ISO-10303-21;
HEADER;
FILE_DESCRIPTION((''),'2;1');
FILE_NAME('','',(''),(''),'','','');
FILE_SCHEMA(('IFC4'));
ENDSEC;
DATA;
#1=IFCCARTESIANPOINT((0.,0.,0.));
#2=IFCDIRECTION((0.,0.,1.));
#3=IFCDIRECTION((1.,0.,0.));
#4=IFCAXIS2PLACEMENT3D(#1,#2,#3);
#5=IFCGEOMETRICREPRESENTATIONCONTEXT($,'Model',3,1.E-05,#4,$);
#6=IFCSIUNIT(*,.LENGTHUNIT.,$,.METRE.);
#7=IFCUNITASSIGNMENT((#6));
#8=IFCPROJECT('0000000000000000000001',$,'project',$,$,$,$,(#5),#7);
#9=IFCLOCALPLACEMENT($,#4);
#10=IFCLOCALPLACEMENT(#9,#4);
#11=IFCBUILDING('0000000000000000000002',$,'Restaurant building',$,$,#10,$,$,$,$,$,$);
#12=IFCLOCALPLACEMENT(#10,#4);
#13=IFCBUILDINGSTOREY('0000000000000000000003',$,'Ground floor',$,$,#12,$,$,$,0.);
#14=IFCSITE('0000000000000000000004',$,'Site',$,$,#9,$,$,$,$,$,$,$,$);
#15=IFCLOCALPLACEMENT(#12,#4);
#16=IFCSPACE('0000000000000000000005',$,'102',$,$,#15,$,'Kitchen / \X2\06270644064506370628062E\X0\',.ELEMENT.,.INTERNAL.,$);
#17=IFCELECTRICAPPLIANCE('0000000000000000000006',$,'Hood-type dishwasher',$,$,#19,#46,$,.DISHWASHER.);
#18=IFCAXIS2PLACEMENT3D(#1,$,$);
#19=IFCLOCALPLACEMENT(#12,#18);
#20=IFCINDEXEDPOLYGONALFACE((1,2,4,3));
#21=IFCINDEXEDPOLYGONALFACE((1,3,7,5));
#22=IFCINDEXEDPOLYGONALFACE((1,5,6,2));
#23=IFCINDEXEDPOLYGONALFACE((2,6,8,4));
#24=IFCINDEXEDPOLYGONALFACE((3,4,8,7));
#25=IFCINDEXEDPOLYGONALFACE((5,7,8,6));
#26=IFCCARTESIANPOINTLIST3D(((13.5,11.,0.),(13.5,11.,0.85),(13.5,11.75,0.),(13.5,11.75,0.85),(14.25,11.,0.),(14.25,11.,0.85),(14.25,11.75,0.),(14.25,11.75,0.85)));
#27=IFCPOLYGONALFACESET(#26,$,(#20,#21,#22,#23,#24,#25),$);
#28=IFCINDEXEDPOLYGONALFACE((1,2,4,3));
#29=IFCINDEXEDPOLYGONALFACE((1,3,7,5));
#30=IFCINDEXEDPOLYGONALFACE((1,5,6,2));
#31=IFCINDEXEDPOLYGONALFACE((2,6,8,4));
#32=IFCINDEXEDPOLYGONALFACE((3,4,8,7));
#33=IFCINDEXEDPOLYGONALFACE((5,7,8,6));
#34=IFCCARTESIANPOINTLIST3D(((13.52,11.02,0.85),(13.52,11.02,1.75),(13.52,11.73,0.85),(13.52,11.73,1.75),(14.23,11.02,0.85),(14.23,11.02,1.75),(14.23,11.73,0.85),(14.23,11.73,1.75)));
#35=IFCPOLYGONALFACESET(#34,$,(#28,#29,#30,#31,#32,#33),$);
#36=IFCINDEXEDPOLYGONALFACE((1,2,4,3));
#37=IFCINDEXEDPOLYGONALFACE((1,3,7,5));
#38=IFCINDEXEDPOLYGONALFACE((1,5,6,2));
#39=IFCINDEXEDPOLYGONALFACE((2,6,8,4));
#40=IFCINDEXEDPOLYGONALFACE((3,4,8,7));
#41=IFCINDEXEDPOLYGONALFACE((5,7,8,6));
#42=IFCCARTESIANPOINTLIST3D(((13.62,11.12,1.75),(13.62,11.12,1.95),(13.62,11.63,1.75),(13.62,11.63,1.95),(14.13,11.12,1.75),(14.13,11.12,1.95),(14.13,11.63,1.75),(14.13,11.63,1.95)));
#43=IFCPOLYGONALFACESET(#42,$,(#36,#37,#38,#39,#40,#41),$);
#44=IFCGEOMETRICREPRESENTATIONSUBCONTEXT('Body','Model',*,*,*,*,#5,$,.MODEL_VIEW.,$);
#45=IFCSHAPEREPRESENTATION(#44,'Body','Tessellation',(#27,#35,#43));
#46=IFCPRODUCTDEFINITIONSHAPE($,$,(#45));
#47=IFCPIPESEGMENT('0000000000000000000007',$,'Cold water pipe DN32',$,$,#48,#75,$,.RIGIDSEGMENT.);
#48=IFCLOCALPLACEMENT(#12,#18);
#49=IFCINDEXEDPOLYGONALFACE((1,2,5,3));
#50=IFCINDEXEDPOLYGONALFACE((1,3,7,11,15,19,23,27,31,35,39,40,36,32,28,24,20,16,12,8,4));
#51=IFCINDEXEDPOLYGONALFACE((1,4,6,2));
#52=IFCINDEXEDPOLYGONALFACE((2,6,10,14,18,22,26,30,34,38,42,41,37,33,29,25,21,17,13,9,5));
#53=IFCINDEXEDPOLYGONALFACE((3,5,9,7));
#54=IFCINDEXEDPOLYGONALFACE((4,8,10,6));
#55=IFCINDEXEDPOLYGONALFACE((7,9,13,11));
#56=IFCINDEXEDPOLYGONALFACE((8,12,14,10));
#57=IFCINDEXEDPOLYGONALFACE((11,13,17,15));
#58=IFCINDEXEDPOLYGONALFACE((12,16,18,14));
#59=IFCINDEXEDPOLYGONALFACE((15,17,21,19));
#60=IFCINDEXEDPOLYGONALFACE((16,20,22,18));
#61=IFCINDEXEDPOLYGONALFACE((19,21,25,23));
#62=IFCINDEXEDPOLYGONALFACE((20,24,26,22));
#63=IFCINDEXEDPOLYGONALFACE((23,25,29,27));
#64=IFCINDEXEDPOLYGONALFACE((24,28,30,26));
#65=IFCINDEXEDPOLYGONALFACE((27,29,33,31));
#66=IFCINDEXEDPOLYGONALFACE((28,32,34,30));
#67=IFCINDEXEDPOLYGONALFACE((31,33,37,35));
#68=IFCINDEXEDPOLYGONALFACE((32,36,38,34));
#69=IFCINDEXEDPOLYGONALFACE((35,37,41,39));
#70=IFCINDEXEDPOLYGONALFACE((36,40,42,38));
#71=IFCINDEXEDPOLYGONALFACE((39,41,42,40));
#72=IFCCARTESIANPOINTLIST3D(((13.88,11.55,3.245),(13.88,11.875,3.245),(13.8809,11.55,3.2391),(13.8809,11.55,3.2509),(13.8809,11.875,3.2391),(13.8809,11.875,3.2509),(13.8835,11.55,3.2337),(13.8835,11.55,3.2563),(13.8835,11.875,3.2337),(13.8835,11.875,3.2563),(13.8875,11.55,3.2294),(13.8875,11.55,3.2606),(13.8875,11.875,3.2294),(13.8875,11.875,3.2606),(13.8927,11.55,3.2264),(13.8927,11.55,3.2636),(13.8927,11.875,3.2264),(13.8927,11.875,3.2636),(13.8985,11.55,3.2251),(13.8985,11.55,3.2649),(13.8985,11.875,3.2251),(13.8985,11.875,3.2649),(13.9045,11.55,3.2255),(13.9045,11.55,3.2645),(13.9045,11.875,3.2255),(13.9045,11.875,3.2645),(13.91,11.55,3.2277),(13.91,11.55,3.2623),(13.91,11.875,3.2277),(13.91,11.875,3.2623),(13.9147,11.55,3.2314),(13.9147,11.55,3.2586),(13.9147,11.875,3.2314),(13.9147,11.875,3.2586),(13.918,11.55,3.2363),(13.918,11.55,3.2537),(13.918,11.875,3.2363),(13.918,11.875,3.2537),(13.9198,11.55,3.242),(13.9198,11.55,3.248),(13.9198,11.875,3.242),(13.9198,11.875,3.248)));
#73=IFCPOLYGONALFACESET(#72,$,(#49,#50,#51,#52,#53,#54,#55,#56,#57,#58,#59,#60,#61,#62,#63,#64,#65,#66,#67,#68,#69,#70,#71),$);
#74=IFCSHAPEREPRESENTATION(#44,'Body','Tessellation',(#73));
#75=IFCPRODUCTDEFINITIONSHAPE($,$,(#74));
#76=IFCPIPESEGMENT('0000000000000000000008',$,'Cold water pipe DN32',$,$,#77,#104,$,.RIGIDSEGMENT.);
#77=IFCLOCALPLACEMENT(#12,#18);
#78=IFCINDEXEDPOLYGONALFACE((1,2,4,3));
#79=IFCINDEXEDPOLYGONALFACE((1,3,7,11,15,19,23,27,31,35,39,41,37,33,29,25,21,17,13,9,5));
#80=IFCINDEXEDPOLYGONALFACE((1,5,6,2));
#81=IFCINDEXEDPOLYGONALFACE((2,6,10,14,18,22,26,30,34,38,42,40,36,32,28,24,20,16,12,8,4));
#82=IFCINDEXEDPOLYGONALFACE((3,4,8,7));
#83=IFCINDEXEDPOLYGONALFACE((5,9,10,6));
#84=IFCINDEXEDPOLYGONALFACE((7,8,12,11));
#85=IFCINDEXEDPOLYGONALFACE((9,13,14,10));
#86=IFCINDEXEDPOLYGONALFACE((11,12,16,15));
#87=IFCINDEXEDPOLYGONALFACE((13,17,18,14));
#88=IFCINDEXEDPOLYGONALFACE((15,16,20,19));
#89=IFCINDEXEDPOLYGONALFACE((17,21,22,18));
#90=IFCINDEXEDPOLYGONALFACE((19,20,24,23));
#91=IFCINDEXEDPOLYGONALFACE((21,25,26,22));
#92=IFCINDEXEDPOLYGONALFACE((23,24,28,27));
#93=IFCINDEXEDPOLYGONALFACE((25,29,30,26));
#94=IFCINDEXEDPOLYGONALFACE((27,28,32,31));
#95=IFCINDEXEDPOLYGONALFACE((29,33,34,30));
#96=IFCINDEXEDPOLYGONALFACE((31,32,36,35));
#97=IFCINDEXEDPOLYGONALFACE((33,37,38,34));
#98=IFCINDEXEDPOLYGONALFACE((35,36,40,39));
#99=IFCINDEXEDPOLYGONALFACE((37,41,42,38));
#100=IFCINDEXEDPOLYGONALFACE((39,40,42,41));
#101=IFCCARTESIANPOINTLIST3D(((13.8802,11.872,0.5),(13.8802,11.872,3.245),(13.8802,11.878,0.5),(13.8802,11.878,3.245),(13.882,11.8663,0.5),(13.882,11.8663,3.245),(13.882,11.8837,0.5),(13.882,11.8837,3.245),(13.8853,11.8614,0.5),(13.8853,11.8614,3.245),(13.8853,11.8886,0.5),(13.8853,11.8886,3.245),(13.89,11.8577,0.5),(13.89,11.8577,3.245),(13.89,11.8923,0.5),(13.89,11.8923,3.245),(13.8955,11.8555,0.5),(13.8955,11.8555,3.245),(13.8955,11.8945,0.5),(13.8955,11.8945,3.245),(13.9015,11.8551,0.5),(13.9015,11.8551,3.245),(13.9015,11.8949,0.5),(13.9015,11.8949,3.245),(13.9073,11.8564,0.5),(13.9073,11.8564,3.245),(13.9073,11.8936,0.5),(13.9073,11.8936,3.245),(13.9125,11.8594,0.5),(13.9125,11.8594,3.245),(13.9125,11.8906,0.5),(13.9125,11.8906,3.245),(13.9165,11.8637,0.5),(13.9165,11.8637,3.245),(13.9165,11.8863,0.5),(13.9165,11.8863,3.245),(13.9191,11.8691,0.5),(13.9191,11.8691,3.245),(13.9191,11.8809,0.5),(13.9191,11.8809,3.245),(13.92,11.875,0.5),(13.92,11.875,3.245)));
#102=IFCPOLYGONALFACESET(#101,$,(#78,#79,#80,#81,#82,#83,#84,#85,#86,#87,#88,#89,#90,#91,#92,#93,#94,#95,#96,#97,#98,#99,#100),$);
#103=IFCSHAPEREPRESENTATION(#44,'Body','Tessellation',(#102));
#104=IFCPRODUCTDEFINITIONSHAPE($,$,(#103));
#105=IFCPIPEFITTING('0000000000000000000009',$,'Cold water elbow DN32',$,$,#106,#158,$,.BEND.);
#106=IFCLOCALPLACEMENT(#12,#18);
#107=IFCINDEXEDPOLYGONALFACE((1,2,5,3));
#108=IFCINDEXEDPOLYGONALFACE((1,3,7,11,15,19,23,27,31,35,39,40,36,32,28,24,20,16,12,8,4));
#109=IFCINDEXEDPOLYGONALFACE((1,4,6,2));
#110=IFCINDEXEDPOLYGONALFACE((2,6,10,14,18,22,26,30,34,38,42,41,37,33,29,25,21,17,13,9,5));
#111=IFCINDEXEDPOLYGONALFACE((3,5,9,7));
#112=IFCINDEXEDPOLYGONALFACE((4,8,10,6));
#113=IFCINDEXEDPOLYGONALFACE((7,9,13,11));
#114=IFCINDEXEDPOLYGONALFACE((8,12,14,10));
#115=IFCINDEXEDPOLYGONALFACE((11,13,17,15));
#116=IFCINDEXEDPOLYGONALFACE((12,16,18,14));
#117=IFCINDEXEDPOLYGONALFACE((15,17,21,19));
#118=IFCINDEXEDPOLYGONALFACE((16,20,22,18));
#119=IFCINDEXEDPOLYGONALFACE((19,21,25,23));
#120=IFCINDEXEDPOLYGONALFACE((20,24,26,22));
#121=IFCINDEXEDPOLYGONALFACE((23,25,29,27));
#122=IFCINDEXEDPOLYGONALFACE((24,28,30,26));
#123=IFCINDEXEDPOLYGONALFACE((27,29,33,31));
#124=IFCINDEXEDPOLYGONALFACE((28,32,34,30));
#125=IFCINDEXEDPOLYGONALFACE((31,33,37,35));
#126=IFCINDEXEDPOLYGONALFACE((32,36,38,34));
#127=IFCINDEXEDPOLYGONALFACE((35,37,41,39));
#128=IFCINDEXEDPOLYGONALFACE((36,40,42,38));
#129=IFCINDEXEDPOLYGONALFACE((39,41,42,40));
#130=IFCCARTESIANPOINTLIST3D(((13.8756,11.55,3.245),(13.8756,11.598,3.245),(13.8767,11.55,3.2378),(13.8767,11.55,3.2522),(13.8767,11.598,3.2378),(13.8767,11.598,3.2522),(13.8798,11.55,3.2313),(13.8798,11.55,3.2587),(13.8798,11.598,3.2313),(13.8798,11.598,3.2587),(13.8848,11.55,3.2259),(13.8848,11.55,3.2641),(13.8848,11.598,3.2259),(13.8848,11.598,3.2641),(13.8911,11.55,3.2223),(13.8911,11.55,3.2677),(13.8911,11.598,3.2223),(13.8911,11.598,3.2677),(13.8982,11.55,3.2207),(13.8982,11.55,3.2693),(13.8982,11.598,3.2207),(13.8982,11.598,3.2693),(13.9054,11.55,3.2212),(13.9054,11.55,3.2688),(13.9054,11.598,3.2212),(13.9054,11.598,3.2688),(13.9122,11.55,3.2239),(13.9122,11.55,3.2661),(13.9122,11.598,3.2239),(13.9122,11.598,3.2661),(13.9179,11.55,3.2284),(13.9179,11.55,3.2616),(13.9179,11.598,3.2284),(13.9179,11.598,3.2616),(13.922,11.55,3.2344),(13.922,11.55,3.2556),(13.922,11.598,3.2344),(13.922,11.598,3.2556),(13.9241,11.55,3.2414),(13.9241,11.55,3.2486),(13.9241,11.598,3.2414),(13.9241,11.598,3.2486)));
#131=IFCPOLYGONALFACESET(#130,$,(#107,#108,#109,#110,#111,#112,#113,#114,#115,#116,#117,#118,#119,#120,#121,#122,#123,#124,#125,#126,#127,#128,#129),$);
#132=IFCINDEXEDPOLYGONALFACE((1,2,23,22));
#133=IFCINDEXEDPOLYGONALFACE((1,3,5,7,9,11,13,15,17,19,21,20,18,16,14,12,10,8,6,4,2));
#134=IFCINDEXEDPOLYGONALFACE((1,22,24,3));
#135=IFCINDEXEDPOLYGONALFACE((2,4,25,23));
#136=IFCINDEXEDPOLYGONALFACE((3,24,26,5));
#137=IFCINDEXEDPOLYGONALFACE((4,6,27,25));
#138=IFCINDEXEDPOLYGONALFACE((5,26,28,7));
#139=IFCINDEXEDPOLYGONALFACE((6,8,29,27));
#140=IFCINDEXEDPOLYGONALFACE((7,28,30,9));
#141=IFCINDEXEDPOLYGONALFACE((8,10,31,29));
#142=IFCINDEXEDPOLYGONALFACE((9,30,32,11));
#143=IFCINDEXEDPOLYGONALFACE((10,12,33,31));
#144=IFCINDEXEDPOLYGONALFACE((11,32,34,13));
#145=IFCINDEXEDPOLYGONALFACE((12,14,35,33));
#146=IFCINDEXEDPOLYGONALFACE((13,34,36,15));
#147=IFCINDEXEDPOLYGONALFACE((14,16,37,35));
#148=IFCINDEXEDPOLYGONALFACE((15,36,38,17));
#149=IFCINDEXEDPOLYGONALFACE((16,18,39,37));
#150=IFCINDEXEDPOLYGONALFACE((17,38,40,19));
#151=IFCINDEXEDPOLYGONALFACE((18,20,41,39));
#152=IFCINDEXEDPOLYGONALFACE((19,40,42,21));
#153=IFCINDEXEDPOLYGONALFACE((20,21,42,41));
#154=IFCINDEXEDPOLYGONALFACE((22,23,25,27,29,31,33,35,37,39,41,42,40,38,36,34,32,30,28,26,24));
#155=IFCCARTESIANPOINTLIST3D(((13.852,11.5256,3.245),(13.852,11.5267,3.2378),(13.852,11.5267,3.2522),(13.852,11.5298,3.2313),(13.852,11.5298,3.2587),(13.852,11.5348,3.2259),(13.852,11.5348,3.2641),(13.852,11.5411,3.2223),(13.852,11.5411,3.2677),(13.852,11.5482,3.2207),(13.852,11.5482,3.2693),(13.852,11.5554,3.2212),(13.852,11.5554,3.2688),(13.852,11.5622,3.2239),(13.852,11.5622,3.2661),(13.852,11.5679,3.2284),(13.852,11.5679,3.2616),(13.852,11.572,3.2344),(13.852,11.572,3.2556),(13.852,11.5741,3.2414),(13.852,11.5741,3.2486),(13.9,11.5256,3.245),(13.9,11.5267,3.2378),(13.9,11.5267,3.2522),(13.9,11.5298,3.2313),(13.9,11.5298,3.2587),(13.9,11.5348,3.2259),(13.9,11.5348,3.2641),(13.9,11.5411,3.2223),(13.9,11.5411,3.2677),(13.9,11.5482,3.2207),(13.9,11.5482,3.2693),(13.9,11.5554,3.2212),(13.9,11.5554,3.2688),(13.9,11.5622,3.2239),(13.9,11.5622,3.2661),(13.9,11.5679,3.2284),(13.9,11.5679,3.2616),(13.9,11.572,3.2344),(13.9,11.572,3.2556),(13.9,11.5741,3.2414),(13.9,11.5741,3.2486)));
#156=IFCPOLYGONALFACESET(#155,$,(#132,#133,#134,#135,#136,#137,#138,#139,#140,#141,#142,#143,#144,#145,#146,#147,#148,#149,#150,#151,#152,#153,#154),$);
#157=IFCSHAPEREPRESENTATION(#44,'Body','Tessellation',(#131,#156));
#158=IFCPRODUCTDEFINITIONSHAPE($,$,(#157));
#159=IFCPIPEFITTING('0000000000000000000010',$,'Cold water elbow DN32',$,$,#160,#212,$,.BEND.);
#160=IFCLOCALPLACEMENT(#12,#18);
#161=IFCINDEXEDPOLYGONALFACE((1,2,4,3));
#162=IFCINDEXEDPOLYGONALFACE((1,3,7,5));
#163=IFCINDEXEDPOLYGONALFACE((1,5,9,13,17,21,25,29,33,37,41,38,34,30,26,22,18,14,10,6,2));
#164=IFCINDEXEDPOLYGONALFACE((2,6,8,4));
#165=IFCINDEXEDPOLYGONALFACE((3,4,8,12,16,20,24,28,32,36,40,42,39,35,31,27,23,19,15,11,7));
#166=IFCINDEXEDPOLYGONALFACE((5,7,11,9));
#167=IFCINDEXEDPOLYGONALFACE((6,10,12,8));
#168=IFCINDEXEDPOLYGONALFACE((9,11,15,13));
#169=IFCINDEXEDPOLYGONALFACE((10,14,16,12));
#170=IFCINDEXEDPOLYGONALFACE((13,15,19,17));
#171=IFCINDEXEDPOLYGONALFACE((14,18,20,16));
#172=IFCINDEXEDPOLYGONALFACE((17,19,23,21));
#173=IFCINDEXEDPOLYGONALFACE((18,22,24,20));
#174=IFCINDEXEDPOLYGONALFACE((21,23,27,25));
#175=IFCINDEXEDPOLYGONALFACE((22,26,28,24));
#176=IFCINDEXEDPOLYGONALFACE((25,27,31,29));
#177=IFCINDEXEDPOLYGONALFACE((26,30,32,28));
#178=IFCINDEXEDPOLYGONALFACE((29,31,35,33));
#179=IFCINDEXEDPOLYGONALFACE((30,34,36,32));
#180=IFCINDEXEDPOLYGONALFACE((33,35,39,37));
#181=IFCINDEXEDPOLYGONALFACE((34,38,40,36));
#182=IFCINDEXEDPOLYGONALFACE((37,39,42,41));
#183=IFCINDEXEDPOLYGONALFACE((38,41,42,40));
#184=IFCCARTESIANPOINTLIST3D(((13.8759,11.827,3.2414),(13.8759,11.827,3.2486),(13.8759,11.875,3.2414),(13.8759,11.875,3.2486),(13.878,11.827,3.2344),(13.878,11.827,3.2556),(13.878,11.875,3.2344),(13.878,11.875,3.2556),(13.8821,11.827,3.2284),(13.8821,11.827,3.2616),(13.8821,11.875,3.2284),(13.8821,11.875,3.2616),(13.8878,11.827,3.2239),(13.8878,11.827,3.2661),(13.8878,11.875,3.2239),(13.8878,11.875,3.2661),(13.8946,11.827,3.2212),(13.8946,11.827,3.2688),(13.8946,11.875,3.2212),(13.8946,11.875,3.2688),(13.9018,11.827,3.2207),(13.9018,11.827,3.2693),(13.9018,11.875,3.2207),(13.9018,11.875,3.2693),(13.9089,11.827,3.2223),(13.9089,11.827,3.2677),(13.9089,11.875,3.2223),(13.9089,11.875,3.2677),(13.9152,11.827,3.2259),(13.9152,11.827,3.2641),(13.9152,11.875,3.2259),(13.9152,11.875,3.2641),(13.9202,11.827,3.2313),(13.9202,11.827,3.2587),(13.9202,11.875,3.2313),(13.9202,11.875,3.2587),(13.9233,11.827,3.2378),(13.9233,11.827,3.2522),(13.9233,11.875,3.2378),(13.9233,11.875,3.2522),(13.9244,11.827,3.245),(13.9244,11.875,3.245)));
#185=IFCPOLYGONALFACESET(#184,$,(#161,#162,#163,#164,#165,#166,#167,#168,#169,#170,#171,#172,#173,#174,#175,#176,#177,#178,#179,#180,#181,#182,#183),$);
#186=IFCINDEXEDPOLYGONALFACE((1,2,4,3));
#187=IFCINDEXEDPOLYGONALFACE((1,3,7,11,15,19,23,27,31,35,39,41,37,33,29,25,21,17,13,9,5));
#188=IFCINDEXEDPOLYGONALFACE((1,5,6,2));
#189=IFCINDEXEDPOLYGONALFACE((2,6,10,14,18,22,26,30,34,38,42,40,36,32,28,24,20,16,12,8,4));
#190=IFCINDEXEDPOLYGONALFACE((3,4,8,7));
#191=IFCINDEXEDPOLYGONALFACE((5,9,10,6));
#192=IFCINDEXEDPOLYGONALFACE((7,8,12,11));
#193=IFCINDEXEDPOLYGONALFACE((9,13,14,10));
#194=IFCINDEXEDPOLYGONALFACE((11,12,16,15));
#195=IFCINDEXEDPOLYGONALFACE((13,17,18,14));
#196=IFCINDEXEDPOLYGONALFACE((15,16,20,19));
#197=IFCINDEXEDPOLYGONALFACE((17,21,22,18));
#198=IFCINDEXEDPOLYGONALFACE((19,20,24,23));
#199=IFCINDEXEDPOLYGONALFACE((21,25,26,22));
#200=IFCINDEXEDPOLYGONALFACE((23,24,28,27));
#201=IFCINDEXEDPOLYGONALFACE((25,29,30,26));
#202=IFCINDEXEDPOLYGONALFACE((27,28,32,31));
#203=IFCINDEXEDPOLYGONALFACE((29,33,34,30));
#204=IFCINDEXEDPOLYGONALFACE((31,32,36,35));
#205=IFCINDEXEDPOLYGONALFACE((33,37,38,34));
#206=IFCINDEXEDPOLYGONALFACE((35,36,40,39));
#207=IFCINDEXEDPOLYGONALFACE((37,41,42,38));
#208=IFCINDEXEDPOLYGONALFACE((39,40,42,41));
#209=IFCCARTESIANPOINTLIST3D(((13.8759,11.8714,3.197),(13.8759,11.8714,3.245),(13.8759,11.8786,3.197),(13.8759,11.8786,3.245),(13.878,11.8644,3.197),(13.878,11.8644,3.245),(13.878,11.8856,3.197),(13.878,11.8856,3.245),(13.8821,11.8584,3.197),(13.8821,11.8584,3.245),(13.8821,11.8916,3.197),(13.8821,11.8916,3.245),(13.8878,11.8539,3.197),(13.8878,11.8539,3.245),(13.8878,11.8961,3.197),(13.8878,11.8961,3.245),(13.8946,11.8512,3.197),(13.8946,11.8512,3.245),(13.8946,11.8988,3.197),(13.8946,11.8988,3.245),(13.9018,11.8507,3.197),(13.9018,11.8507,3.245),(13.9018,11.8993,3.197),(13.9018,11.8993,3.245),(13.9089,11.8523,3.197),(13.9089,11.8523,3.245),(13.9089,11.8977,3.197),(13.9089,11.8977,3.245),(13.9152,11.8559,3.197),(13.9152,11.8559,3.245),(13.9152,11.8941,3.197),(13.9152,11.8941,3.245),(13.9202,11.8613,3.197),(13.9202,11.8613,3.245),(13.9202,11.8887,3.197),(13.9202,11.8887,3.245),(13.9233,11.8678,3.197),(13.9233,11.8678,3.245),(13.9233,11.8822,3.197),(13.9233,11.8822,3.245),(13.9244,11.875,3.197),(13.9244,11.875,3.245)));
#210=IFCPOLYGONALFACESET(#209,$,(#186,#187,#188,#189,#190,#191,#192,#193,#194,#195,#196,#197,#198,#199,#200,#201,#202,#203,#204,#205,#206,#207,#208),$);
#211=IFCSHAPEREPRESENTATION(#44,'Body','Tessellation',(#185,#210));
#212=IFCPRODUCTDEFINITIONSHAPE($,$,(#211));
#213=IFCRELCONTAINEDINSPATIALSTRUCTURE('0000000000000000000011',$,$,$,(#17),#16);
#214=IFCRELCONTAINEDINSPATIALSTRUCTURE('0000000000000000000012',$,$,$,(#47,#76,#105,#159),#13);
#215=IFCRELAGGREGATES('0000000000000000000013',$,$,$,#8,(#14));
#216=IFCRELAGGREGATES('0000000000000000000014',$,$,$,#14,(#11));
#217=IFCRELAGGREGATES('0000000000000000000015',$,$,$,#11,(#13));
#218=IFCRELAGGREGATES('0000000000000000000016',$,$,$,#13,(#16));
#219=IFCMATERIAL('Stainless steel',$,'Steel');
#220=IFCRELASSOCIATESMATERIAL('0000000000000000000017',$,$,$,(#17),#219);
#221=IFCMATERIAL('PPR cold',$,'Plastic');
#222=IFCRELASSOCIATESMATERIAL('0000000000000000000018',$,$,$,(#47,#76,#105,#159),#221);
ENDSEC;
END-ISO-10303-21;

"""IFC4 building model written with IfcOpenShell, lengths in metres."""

from ifc_helpers import new_model, si_unit, frame, origin_with_axes, origin_2d, place, context, subcontext, project, spatial, rectangle, circle, extrude, material, element, save


model = new_model("IFC4")

# Units and contexts
model_context = context("Model", 3, precision=1e-05, world=origin_with_axes())
body_context = subcontext(model_context, "Body", "Model", "MODEL_VIEW")
ifc_project = project(units=[si_unit("LENGTHUNIT", "METRE")], contexts=[model_context])

# Site, building, storey, space
site_placement = place(None, origin_with_axes())
site = spatial("IfcSite", under=ifc_project, at=site_placement, Name="Site")
building_placement = place(site_placement, origin_with_axes())
building = spatial("IfcBuilding", under=site, at=building_placement, Name="Restaurant building")
storey_placement = place(building_placement, origin_with_axes())
storey = spatial("IfcBuildingStorey", under=building, at=storey_placement, Name="Ground floor", Elevation=0.0)
space_placement = place(storey_placement, origin_with_axes())
space = spatial("IfcSpace", under=storey, at=space_placement, Name="102", LongName="Kitchen / المطبخ", CompositionType="ELEMENT", PredefinedType="INTERNAL")

# Electric appliance
ifc_material_1 = material(Name="Stainless steel", Category="Steel")
electric_appliance_placement = place(storey_placement, frame((13.5, 11.0, 0.0)))
element("IfcElectricAppliance", 1, at=electric_appliance_placement, inside=space, material=ifc_material_1, Name="Hood-type dishwasher", PredefinedType="DISHWASHER", context=body_context, shape_type="SweptSolid", body=[
    extrude(rectangle(XDim=0.75, YDim=0.75, at=origin_2d()), frame((0.375, 0.375, 0.0)), (0.0, 0.0, 1.0), 0.85),
    extrude(rectangle(XDim=0.71, YDim=0.71, at=origin_2d()), frame((0.375, 0.375, 0.85)), (0.0, 0.0, 1.0), 0.9),
    extrude(rectangle(XDim=0.51, YDim=0.51, at=origin_2d()), frame((0.375, 0.375, 1.75)), (0.0, 0.0, 1.0), 0.2),
])

# Pipe segments
ifc_material_2 = material(Name="PPR cold", Category="Plastic")
pipe_segment_1_placement = place(storey_placement, frame((13.9, 11.55, 3.245)))
element("IfcPipeSegment", 2, at=pipe_segment_1_placement, inside=storey, material=ifc_material_2, Name="Cold water pipe DN32", PredefinedType="RIGIDSEGMENT", context=body_context, shape_type="SweptSolid", body=[
    extrude(circle(Radius=0.02, at=origin_2d()), frame((0.0, 0.0, 0.0), z_axis=(0.0, 1.0, 0.0), x_axis=(-1.0, 0.0, 0.0)), (0.0, 0.0, 1.0), 0.325),
])
pipe_segment_2_placement = place(storey_placement, frame((13.9, 11.875, 3.245)))
element("IfcPipeSegment", 3, at=pipe_segment_2_placement, inside=storey, material=ifc_material_2, Name="Cold water pipe DN32", PredefinedType="RIGIDSEGMENT", context=body_context, shape_type="SweptSolid", body=[
    extrude(circle(Radius=0.02, at=origin_2d()), frame((0.0, 0.0, 0.0), z_axis=(0.0, 0.0, -1.0), x_axis=(1.0, 0.0, 0.0)), (0.0, 0.0, 1.0), 2.745),
])

# Pipe fittings
pipe_fitting_1_placement = place(storey_placement, frame((13.9, 11.55, 3.245)))
element("IfcPipeFitting", 4, at=pipe_fitting_1_placement, inside=storey, material=ifc_material_2, Name="Cold water elbow DN32", PredefinedType="BEND", context=body_context, shape_type="SweptSolid", body=[
    extrude(circle(Radius=0.0244, at=origin_2d()), frame((0.0, 0.0, 0.0), z_axis=(0.0, 1.0, 0.0), x_axis=(-1.0, 0.0, 0.0)), (0.0, 0.0, 1.0), 0.048),
    extrude(circle(Radius=0.0244, at=origin_2d()), frame((0.0, 0.0, 0.0), z_axis=(-1.0, 0.0, 0.0), x_axis=(0.0, -1.0, 0.0)), (0.0, 0.0, 1.0), 0.048),
])
pipe_fitting_2_placement = place(storey_placement, frame((13.9, 11.875, 3.245)))
element("IfcPipeFitting", 5, at=pipe_fitting_2_placement, inside=storey, material=ifc_material_2, Name="Cold water elbow DN32", PredefinedType="BEND", context=body_context, shape_type="SweptSolid", body=[
    extrude(circle(Radius=0.0244, at=origin_2d()), frame((0.0, 0.0, 0.0), z_axis=(0.0, -1.0, 0.0), x_axis=(1.0, 0.0, 0.0)), (0.0, 0.0, 1.0), 0.048),
    extrude(circle(Radius=0.0244, at=origin_2d()), frame((0.0, 0.0, 0.0), z_axis=(0.0, 0.0, -1.0), x_axis=(1.0, 0.0, 0.0)), (0.0, 0.0, 1.0), 0.048),
])

save(model, "model.ifc")
